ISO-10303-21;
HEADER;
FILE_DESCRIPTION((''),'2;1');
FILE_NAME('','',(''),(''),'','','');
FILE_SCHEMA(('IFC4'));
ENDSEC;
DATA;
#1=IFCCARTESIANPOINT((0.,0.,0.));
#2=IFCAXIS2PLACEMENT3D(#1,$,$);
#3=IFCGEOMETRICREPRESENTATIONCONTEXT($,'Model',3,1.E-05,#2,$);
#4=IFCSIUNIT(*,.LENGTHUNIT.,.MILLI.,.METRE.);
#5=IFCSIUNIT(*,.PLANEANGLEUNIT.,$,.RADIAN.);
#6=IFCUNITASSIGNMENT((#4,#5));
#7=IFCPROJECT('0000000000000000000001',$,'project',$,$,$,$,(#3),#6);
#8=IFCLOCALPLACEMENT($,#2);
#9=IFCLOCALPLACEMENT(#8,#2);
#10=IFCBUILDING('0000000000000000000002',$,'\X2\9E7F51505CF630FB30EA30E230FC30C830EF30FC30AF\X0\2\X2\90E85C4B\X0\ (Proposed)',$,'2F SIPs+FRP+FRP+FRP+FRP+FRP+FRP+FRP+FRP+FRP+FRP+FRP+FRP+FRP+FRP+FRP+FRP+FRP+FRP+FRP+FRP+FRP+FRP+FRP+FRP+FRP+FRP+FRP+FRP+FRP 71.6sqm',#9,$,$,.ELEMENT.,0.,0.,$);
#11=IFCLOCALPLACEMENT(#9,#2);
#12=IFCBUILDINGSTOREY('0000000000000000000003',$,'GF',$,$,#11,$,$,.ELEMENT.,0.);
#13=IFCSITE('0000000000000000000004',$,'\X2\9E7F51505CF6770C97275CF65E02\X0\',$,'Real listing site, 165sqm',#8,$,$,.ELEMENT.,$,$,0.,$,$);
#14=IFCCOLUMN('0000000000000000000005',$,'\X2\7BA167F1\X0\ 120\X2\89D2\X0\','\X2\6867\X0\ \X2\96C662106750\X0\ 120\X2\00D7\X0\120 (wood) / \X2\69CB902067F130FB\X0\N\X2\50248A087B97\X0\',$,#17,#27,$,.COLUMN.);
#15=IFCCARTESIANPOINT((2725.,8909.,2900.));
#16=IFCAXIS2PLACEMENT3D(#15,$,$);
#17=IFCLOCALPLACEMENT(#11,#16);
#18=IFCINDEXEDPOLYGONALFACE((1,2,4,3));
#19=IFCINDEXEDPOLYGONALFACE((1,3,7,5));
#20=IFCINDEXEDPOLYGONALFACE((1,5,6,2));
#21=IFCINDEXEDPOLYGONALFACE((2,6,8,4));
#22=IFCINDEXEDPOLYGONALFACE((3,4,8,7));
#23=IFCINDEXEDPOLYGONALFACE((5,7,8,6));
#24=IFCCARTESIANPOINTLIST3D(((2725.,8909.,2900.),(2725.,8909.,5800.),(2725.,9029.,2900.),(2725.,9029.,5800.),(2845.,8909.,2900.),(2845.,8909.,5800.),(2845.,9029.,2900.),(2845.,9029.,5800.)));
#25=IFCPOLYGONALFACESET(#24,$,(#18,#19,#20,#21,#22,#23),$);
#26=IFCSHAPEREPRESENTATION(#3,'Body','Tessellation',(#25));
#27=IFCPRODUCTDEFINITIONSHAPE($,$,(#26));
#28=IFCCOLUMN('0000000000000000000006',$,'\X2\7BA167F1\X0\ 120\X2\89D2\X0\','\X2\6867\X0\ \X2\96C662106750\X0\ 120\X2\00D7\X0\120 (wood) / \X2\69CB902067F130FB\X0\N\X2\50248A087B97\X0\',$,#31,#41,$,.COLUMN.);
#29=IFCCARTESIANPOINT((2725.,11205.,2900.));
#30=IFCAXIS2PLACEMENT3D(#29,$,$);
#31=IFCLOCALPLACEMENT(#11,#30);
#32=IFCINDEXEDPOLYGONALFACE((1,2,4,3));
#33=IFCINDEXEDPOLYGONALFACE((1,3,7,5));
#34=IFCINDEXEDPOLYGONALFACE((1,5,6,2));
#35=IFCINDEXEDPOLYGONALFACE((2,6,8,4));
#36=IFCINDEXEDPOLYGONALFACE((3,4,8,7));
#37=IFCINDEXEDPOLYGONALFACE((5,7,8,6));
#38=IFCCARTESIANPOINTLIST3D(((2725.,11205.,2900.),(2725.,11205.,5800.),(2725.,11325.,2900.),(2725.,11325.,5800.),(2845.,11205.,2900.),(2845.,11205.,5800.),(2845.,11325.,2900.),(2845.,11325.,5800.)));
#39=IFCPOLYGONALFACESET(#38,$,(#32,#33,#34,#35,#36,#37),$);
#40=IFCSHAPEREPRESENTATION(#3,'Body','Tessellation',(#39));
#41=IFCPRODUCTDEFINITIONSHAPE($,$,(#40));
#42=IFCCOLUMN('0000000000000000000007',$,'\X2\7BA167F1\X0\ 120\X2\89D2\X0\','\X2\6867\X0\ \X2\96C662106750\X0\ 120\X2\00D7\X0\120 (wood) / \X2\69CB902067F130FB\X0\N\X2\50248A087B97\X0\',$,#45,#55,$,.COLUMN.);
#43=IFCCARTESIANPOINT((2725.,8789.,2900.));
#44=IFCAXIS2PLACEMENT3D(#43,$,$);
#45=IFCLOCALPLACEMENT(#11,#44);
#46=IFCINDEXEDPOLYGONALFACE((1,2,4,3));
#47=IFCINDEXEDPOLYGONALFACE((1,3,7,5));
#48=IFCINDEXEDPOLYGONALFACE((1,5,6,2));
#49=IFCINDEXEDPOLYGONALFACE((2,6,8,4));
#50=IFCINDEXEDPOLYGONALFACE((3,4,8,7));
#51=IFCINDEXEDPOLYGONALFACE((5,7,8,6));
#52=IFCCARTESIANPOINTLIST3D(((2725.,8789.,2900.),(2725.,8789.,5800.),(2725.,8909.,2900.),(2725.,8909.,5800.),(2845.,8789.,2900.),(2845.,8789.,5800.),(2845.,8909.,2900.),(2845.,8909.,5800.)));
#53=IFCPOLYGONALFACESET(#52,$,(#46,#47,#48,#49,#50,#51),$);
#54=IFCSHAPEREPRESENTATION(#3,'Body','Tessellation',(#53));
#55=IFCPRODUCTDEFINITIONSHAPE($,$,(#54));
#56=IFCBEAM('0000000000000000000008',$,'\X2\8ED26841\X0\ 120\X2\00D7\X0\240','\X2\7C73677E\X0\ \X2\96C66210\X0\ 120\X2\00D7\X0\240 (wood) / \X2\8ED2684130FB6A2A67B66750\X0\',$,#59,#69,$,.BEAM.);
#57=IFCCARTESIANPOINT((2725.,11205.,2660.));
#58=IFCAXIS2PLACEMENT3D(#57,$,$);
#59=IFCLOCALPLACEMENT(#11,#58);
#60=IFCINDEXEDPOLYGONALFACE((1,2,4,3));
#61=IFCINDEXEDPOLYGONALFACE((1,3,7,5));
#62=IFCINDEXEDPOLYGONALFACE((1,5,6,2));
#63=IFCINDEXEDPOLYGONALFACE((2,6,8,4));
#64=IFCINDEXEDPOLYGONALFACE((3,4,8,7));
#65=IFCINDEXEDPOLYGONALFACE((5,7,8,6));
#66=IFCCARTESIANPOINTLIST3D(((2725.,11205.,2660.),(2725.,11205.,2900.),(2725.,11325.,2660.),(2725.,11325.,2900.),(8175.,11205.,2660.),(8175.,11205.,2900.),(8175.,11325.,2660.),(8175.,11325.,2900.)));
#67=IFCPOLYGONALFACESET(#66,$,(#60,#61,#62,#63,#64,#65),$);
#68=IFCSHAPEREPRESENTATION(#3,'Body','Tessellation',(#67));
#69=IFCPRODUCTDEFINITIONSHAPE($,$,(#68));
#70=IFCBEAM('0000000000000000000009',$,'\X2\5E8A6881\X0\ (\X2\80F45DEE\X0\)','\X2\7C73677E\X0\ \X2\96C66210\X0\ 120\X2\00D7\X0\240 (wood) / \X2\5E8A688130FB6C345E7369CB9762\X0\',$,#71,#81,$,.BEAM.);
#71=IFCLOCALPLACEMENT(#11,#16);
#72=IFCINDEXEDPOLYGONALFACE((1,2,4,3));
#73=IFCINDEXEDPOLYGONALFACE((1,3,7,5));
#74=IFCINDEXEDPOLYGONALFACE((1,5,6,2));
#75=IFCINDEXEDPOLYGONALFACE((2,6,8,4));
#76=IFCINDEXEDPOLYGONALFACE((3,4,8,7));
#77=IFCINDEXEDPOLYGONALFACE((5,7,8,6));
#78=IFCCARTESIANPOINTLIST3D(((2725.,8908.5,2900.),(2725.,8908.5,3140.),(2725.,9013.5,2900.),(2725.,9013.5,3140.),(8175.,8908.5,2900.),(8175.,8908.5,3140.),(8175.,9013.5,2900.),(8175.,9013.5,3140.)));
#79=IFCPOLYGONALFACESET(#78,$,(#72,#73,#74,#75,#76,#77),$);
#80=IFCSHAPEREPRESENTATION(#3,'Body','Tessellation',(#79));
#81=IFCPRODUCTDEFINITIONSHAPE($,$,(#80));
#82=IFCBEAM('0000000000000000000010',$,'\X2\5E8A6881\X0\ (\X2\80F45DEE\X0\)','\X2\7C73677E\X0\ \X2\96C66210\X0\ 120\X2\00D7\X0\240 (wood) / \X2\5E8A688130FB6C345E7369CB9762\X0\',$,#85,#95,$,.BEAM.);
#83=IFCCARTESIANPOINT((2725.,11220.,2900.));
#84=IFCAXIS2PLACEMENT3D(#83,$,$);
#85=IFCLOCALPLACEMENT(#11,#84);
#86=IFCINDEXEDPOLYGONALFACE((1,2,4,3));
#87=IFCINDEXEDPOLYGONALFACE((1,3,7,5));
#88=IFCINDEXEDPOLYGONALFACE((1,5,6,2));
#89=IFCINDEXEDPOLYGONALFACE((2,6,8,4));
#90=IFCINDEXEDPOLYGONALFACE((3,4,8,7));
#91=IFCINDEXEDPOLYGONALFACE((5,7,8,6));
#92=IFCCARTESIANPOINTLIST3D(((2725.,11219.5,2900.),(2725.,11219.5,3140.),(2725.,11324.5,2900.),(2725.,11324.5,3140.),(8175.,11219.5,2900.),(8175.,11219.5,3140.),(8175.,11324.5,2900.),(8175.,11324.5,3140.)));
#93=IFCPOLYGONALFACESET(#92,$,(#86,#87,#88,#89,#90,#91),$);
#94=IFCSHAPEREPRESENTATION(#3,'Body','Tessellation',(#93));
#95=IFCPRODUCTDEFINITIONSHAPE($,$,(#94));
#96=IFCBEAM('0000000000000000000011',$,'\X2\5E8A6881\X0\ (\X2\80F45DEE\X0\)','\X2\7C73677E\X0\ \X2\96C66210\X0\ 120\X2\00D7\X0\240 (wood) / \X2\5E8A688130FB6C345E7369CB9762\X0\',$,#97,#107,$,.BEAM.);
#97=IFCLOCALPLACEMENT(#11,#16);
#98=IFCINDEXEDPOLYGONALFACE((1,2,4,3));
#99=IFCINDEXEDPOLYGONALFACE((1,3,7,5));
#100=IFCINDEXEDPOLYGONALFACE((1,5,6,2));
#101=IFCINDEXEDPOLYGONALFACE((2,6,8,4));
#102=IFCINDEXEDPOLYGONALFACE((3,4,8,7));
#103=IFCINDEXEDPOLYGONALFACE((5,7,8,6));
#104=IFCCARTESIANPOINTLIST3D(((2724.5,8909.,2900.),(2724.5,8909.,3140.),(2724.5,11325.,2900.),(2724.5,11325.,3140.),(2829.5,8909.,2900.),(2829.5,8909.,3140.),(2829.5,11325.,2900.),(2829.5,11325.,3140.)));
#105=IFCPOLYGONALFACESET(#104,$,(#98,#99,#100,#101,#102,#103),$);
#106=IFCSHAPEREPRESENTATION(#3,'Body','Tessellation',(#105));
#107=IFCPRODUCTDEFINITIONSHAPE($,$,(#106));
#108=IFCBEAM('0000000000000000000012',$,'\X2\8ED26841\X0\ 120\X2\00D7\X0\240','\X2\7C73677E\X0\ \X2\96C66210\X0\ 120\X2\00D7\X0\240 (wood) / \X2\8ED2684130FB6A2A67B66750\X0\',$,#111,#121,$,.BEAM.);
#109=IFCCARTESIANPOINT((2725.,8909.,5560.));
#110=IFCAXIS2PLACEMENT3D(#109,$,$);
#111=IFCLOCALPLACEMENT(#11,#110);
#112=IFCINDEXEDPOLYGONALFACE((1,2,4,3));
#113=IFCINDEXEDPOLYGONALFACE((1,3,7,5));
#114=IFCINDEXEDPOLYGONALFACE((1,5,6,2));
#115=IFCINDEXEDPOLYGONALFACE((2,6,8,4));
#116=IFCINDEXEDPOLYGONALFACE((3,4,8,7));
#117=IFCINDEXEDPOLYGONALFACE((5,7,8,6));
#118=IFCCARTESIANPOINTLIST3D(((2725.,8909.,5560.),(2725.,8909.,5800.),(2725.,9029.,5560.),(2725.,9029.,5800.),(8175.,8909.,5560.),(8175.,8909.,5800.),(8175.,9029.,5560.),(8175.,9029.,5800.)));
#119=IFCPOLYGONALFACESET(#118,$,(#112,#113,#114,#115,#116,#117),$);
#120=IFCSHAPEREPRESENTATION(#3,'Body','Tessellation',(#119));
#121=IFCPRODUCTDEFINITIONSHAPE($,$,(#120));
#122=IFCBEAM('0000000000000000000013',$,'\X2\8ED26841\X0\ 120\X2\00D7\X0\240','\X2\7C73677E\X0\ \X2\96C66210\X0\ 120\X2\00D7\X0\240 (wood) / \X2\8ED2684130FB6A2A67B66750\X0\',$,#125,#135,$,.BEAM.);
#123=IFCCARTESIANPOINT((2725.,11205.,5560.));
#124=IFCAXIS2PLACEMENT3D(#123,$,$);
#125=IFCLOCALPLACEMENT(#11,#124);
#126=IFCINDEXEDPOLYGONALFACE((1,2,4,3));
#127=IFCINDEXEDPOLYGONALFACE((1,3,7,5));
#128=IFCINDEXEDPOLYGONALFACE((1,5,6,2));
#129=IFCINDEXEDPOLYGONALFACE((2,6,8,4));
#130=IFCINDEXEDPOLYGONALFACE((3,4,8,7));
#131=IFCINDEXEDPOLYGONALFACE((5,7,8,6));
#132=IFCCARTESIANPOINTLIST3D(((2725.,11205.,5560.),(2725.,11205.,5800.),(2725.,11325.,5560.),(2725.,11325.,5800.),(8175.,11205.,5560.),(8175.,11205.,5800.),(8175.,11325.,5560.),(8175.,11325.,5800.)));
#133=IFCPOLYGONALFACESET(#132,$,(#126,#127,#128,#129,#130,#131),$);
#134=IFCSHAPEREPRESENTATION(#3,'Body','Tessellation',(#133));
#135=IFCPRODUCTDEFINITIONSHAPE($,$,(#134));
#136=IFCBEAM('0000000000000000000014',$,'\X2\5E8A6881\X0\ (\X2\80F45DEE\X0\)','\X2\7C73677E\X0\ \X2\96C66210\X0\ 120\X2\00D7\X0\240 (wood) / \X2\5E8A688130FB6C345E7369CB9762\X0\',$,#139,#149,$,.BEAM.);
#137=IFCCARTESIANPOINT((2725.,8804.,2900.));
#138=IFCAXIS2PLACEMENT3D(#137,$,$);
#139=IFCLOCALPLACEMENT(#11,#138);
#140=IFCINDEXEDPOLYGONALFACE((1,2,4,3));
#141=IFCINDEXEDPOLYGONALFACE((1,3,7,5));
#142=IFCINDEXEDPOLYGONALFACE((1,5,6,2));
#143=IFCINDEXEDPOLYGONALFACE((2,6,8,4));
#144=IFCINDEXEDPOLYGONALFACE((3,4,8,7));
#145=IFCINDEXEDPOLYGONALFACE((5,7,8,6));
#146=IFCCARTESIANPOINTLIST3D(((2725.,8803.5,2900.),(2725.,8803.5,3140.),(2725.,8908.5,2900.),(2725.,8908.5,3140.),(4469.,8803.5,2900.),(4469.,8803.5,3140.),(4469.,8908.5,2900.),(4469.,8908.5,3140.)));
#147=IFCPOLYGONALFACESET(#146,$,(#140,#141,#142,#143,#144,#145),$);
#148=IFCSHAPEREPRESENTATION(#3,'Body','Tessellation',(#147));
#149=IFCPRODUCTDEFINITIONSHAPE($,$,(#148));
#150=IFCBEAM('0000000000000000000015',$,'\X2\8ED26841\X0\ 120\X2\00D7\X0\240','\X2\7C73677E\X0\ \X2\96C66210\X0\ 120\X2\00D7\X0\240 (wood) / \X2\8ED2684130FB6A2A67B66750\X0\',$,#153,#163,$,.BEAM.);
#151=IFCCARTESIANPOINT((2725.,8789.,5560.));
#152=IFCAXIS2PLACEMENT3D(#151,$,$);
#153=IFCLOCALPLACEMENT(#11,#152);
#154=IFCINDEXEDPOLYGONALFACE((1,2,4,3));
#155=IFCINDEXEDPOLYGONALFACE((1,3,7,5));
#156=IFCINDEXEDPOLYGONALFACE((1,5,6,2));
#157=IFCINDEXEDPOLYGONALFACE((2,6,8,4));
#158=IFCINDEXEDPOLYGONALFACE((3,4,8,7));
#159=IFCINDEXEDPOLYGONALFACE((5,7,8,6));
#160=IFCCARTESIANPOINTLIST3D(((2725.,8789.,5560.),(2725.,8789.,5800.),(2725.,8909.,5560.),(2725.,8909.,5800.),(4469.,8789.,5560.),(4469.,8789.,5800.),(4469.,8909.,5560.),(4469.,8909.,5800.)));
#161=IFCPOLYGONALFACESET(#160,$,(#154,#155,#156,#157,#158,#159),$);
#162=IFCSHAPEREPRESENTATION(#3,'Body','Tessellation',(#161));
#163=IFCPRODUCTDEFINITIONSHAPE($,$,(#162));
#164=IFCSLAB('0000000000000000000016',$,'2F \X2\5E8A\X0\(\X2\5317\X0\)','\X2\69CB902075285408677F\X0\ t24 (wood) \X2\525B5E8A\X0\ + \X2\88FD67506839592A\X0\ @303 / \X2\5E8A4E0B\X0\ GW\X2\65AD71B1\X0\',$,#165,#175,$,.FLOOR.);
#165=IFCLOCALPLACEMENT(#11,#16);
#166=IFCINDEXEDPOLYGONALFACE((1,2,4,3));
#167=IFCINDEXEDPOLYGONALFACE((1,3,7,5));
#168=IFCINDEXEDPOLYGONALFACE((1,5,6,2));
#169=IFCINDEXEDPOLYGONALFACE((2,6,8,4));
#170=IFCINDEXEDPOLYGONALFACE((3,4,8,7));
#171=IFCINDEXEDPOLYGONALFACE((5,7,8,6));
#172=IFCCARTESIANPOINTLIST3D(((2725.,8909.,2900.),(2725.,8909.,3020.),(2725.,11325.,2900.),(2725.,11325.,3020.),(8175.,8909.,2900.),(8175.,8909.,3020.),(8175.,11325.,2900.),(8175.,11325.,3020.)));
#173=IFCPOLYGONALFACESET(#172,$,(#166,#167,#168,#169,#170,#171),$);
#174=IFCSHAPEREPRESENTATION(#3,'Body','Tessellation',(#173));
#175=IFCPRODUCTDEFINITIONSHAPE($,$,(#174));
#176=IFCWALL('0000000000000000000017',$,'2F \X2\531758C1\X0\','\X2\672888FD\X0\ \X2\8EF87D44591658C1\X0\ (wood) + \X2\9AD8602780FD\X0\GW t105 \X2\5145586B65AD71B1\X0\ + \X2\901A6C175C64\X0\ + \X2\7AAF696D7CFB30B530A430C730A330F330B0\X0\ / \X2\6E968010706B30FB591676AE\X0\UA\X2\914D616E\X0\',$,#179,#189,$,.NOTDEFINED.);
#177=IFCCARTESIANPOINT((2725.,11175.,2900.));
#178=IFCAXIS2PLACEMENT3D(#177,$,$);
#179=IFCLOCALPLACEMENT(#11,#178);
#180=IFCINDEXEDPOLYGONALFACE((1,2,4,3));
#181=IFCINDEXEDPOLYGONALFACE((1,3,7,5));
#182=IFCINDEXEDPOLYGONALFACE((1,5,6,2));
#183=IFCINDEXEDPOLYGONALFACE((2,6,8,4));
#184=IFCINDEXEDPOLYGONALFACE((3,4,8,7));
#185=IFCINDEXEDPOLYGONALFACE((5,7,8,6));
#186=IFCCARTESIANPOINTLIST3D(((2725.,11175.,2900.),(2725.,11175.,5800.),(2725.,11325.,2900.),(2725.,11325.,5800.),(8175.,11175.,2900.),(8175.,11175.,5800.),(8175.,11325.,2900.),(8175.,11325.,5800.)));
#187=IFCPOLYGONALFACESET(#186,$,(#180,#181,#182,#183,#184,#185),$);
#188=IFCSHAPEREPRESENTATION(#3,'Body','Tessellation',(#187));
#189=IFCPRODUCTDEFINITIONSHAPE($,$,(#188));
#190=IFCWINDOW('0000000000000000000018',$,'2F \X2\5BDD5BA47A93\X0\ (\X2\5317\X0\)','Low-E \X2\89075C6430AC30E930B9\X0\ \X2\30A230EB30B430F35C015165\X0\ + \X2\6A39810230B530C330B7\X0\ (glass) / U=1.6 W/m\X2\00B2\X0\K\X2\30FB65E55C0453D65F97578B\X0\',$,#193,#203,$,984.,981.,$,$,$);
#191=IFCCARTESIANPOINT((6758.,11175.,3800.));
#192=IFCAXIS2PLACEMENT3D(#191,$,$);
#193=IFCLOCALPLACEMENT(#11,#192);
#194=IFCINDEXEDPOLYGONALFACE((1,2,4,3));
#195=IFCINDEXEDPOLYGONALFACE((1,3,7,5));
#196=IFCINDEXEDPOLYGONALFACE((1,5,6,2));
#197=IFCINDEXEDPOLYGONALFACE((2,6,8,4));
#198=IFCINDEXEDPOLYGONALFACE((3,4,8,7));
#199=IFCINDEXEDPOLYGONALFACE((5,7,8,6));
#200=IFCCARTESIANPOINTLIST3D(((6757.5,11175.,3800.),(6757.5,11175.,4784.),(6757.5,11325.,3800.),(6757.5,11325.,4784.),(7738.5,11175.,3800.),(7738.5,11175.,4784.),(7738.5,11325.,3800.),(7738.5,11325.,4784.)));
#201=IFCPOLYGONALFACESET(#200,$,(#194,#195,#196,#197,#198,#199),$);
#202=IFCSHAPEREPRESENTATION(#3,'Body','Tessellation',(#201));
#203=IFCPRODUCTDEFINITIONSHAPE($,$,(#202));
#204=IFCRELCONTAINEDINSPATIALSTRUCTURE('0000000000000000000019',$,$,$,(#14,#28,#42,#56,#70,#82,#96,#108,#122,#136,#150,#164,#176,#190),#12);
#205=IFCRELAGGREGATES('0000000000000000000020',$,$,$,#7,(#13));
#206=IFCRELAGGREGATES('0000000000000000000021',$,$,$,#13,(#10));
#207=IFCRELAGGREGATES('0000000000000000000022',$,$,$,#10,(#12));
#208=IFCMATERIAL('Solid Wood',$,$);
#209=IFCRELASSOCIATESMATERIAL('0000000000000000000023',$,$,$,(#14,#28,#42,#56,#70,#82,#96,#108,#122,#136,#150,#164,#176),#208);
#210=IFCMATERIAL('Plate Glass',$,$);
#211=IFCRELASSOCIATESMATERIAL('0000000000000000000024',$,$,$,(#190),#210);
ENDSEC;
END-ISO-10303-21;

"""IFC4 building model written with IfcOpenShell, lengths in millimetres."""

from ifc_helpers import new_model, si_unit, frame, frame_2d, origin, place, context, project, spatial, rectangle, extrude, material, element, fill, save


model = new_model("IFC4")

# Units and contexts
model_context = context("Model", 3, precision=1e-05, world=origin())
ifc_project = project(units=[si_unit("LENGTHUNIT", "METRE", prefix="MILLI"), si_unit("PLANEANGLEUNIT", "RADIAN")], contexts=[model_context])

# Site, building, storey
site_placement = place(None, origin())
site = spatial("IfcSite", under=ifc_project, at=site_placement, Name="鹿児島県霧島市", ObjectType="Real listing site, 165sqm", CompositionType="ELEMENT", RefElevation=0.0)
building_placement = place(site_placement, origin())
building = spatial("IfcBuilding", under=site, at=building_placement, Name="鹿児島・リモートワーク2部屋 (Proposed)", ObjectType="2F SIPs+FRP+FRP+FRP+FRP+FRP+FRP+FRP+FRP+FRP+FRP+FRP+FRP+FRP+FRP+FRP+FRP+FRP+FRP+FRP+FRP+FRP+FRP+FRP+FRP+FRP+FRP+FRP+FRP+FRP 71.6sqm", CompositionType="ELEMENT", ElevationOfRefHeight=0.0, ElevationOfTerrain=0.0)
storey_placement = place(building_placement, origin())
storey = spatial("IfcBuildingStorey", under=building, at=storey_placement, Name="GF", CompositionType="ELEMENT", Elevation=0.0)

# Columns
ifc_material_1 = material(Name="Solid Wood")
column_1_placement = place(storey_placement, frame((2725.0, 8909.0, 2900.0)))
element("IfcColumn", 1, at=column_1_placement, inside=storey, material=ifc_material_1, Name="管柱 120角", Description="桧 集成材 120×120 (wood) / 構造柱・N値計算", PredefinedType="COLUMN", context=model_context, shape_type="SweptSolid", body=[
    extrude(rectangle(XDim=120.0, YDim=120.0, at=frame_2d((60.0, 60.0))), frame((2725.0, 8909.0, 2900.0)), (0.0, 0.0, 1.0), 2900.0),
])
column_2_placement = place(storey_placement, frame((2725.0, 11205.0, 2900.0)))
element("IfcColumn", 2, at=column_2_placement, inside=storey, material=ifc_material_1, Name="管柱 120角", Description="桧 集成材 120×120 (wood) / 構造柱・N値計算", PredefinedType="COLUMN", context=model_context, shape_type="SweptSolid", body=[
    extrude(rectangle(XDim=120.0, YDim=120.0, at=frame_2d((60.0, 60.0))), frame((2725.0, 11205.0, 2900.0)), (0.0, 0.0, 1.0), 2900.0),
])
column_3_placement = place(storey_placement, frame((2725.0, 8789.0, 2900.0)))
element("IfcColumn", 3, at=column_3_placement, inside=storey, material=ifc_material_1, Name="管柱 120角", Description="桧 集成材 120×120 (wood) / 構造柱・N値計算", PredefinedType="COLUMN", context=model_context, shape_type="SweptSolid", body=[
    extrude(rectangle(XDim=120.0, YDim=120.0, at=frame_2d((60.0, 60.0))), frame((2725.0, 8789.0, 2900.0)), (0.0, 0.0, 1.0), 2900.0),
])

# Beams
beam_1_placement = place(storey_placement, frame((2725.0, 11205.0, 2660.0)))
element("IfcBeam", 4, at=beam_1_placement, inside=storey, material=ifc_material_1, Name="軒桁 120×240", Description="米松 集成 120×240 (wood) / 軒桁・横架材", PredefinedType="BEAM", context=model_context, shape_type="SweptSolid", body=[
    extrude(rectangle(XDim=5450.0, YDim=120.0, at=frame_2d((2725.0, 60.0))), frame((2725.0, 11205.0, 2660.0)), (0.0, 0.0, 1.0), 240.0),
])
beam_2_placement = place(storey_placement, frame((2725.0, 8909.0, 2900.0)))
element("IfcBeam", 5, at=beam_2_placement, inside=storey, material=ifc_material_1, Name="床梁 (胴差)", Description="米松 集成 120×240 (wood) / 床梁・水平構面", PredefinedType="BEAM", context=model_context, shape_type="SweptSolid", body=[
    extrude(rectangle(XDim=5450.0, YDim=105.0, at=frame_2d((2725.0, 52.0))), frame((2725.0, 8909.0, 2900.0)), (0.0, 0.0, 1.0), 240.0),
])
beam_3_placement = place(storey_placement, frame((2725.0, 11220.0, 2900.0)))
element("IfcBeam", 6, at=beam_3_placement, inside=storey, material=ifc_material_1, Name="床梁 (胴差)", Description="米松 集成 120×240 (wood) / 床梁・水平構面", PredefinedType="BEAM", context=model_context, shape_type="SweptSolid", body=[
    extrude(rectangle(XDim=5450.0, YDim=105.0, at=frame_2d((2725.0, 52.0))), frame((2725.0, 11220.0, 2900.0)), (0.0, 0.0, 1.0), 240.0),
])
beam_4_placement = place(storey_placement, frame((2725.0, 8909.0, 2900.0)))
element("IfcBeam", 7, at=beam_4_placement, inside=storey, material=ifc_material_1, Name="床梁 (胴差)", Description="米松 集成 120×240 (wood) / 床梁・水平構面", PredefinedType="BEAM", context=model_context, shape_type="SweptSolid", body=[
    extrude(rectangle(XDim=105.0, YDim=2416.0, at=frame_2d((52.0, 1208.0))), frame((2725.0, 8909.0, 2900.0)), (0.0, 0.0, 1.0), 240.0),
])
beam_5_placement = place(storey_placement, frame((2725.0, 8909.0, 5560.0)))
element("IfcBeam", 8, at=beam_5_placement, inside=storey, material=ifc_material_1, Name="軒桁 120×240", Description="米松 集成 120×240 (wood) / 軒桁・横架材", PredefinedType="BEAM", context=model_context, shape_type="SweptSolid", body=[
    extrude(rectangle(XDim=5450.0, YDim=120.0, at=frame_2d((2725.0, 60.0))), frame((2725.0, 8909.0, 5560.0)), (0.0, 0.0, 1.0), 240.0),
])
beam_6_placement = place(storey_placement, frame((2725.0, 11205.0, 5560.0)))
element("IfcBeam", 9, at=beam_6_placement, inside=storey, material=ifc_material_1, Name="軒桁 120×240", Description="米松 集成 120×240 (wood) / 軒桁・横架材", PredefinedType="BEAM", context=model_context, shape_type="SweptSolid", body=[
    extrude(rectangle(XDim=5450.0, YDim=120.0, at=frame_2d((2725.0, 60.0))), frame((2725.0, 11205.0, 5560.0)), (0.0, 0.0, 1.0), 240.0),
])
beam_7_placement = place(storey_placement, frame((2725.0, 8804.0, 2900.0)))
element("IfcBeam", 10, at=beam_7_placement, inside=storey, material=ifc_material_1, Name="床梁 (胴差)", Description="米松 集成 120×240 (wood) / 床梁・水平構面", PredefinedType="BEAM", context=model_context, shape_type="SweptSolid", body=[
    extrude(rectangle(XDim=1744.0, YDim=105.0, at=frame_2d((872.0, 52.0))), frame((2725.0, 8804.0, 2900.0)), (0.0, 0.0, 1.0), 240.0),
])
beam_8_placement = place(storey_placement, frame((2725.0, 8789.0, 5560.0)))
element("IfcBeam", 11, at=beam_8_placement, inside=storey, material=ifc_material_1, Name="軒桁 120×240", Description="米松 集成 120×240 (wood) / 軒桁・横架材", PredefinedType="BEAM", context=model_context, shape_type="SweptSolid", body=[
    extrude(rectangle(XDim=1744.0, YDim=120.0, at=frame_2d((872.0, 60.0))), frame((2725.0, 8789.0, 5560.0)), (0.0, 0.0, 1.0), 240.0),
])

# Slab
slab_placement = place(storey_placement, frame((2725.0, 8909.0, 2900.0)))
element("IfcSlab", 12, at=slab_placement, inside=storey, material=ifc_material_1, Name="2F 床(北)", Description="構造用合板 t24 (wood) 剛床 + 製材根太 @303 / 床下 GW断熱", PredefinedType="FLOOR", context=model_context, shape_type="SweptSolid", body=[
    extrude(rectangle(XDim=5450.0, YDim=2416.0, at=frame_2d((2725.0, 1208.0))), frame((2725.0, 8909.0, 2900.0)), (0.0, 0.0, 1.0), 120.0),
])

# Wall, opening, window
wall_placement = place(storey_placement, frame((2725.0, 11175.0, 2900.0)))
wall = element("IfcWall", 13, at=wall_placement, inside=storey, material=ifc_material_1, Name="2F 北壁", Description="木製 軸組外壁 (wood) + 高性能GW t105 充填断熱 + 通気層 + 窯業系サイディング / 準耐火・外皮UA配慮", PredefinedType="NOTDEFINED", context=model_context, shape_type="SweptSolid", body=[
    extrude(rectangle(XDim=5450.0, YDim=150.0, at=frame_2d((2725.0, 75.0))), frame((2725.0, 11175.0, 2900.0)), (0.0, 0.0, 1.0), 2900.0),
])
opening_placement = place(storey_placement, frame((6758.0, 11175.0, 3800.0)))
opening = element("IfcOpeningElement", 14, at=opening_placement, cuts=wall, PredefinedType="NOTDEFINED", context=model_context, shape_type="SweptSolid", body=[
    extrude(rectangle(XDim=981.0, YDim=150.0, at=frame_2d((490.0, 75.0))), frame((6758.0, 11175.0, 3800.0)), (0.0, 0.0, 1.0), 984.0),
])
ifc_material_2 = material(Name="Plate Glass")
window_placement = place(storey_placement, frame((6758.0, 11175.0, 3800.0)))
window = element("IfcWindow", 15, at=window_placement, inside=storey, material=ifc_material_2, Name="2F 寝室窓 (北)", Description="Low-E 複層ガラス アルゴン封入 + 樹脂サッシ (glass) / U=1.6 W/m²K・日射取得型", OverallHeight=984.0, OverallWidth=981.0, context=model_context, shape_type="SweptSolid", body=[
    extrude(rectangle(XDim=981.0, YDim=150.0, at=frame_2d((490.0, 75.0))), frame((6758.0, 11175.0, 3800.0)), (0.0, 0.0, 1.0), 984.0),
])
fill(opening, window)

save(model, "model.ifc")
